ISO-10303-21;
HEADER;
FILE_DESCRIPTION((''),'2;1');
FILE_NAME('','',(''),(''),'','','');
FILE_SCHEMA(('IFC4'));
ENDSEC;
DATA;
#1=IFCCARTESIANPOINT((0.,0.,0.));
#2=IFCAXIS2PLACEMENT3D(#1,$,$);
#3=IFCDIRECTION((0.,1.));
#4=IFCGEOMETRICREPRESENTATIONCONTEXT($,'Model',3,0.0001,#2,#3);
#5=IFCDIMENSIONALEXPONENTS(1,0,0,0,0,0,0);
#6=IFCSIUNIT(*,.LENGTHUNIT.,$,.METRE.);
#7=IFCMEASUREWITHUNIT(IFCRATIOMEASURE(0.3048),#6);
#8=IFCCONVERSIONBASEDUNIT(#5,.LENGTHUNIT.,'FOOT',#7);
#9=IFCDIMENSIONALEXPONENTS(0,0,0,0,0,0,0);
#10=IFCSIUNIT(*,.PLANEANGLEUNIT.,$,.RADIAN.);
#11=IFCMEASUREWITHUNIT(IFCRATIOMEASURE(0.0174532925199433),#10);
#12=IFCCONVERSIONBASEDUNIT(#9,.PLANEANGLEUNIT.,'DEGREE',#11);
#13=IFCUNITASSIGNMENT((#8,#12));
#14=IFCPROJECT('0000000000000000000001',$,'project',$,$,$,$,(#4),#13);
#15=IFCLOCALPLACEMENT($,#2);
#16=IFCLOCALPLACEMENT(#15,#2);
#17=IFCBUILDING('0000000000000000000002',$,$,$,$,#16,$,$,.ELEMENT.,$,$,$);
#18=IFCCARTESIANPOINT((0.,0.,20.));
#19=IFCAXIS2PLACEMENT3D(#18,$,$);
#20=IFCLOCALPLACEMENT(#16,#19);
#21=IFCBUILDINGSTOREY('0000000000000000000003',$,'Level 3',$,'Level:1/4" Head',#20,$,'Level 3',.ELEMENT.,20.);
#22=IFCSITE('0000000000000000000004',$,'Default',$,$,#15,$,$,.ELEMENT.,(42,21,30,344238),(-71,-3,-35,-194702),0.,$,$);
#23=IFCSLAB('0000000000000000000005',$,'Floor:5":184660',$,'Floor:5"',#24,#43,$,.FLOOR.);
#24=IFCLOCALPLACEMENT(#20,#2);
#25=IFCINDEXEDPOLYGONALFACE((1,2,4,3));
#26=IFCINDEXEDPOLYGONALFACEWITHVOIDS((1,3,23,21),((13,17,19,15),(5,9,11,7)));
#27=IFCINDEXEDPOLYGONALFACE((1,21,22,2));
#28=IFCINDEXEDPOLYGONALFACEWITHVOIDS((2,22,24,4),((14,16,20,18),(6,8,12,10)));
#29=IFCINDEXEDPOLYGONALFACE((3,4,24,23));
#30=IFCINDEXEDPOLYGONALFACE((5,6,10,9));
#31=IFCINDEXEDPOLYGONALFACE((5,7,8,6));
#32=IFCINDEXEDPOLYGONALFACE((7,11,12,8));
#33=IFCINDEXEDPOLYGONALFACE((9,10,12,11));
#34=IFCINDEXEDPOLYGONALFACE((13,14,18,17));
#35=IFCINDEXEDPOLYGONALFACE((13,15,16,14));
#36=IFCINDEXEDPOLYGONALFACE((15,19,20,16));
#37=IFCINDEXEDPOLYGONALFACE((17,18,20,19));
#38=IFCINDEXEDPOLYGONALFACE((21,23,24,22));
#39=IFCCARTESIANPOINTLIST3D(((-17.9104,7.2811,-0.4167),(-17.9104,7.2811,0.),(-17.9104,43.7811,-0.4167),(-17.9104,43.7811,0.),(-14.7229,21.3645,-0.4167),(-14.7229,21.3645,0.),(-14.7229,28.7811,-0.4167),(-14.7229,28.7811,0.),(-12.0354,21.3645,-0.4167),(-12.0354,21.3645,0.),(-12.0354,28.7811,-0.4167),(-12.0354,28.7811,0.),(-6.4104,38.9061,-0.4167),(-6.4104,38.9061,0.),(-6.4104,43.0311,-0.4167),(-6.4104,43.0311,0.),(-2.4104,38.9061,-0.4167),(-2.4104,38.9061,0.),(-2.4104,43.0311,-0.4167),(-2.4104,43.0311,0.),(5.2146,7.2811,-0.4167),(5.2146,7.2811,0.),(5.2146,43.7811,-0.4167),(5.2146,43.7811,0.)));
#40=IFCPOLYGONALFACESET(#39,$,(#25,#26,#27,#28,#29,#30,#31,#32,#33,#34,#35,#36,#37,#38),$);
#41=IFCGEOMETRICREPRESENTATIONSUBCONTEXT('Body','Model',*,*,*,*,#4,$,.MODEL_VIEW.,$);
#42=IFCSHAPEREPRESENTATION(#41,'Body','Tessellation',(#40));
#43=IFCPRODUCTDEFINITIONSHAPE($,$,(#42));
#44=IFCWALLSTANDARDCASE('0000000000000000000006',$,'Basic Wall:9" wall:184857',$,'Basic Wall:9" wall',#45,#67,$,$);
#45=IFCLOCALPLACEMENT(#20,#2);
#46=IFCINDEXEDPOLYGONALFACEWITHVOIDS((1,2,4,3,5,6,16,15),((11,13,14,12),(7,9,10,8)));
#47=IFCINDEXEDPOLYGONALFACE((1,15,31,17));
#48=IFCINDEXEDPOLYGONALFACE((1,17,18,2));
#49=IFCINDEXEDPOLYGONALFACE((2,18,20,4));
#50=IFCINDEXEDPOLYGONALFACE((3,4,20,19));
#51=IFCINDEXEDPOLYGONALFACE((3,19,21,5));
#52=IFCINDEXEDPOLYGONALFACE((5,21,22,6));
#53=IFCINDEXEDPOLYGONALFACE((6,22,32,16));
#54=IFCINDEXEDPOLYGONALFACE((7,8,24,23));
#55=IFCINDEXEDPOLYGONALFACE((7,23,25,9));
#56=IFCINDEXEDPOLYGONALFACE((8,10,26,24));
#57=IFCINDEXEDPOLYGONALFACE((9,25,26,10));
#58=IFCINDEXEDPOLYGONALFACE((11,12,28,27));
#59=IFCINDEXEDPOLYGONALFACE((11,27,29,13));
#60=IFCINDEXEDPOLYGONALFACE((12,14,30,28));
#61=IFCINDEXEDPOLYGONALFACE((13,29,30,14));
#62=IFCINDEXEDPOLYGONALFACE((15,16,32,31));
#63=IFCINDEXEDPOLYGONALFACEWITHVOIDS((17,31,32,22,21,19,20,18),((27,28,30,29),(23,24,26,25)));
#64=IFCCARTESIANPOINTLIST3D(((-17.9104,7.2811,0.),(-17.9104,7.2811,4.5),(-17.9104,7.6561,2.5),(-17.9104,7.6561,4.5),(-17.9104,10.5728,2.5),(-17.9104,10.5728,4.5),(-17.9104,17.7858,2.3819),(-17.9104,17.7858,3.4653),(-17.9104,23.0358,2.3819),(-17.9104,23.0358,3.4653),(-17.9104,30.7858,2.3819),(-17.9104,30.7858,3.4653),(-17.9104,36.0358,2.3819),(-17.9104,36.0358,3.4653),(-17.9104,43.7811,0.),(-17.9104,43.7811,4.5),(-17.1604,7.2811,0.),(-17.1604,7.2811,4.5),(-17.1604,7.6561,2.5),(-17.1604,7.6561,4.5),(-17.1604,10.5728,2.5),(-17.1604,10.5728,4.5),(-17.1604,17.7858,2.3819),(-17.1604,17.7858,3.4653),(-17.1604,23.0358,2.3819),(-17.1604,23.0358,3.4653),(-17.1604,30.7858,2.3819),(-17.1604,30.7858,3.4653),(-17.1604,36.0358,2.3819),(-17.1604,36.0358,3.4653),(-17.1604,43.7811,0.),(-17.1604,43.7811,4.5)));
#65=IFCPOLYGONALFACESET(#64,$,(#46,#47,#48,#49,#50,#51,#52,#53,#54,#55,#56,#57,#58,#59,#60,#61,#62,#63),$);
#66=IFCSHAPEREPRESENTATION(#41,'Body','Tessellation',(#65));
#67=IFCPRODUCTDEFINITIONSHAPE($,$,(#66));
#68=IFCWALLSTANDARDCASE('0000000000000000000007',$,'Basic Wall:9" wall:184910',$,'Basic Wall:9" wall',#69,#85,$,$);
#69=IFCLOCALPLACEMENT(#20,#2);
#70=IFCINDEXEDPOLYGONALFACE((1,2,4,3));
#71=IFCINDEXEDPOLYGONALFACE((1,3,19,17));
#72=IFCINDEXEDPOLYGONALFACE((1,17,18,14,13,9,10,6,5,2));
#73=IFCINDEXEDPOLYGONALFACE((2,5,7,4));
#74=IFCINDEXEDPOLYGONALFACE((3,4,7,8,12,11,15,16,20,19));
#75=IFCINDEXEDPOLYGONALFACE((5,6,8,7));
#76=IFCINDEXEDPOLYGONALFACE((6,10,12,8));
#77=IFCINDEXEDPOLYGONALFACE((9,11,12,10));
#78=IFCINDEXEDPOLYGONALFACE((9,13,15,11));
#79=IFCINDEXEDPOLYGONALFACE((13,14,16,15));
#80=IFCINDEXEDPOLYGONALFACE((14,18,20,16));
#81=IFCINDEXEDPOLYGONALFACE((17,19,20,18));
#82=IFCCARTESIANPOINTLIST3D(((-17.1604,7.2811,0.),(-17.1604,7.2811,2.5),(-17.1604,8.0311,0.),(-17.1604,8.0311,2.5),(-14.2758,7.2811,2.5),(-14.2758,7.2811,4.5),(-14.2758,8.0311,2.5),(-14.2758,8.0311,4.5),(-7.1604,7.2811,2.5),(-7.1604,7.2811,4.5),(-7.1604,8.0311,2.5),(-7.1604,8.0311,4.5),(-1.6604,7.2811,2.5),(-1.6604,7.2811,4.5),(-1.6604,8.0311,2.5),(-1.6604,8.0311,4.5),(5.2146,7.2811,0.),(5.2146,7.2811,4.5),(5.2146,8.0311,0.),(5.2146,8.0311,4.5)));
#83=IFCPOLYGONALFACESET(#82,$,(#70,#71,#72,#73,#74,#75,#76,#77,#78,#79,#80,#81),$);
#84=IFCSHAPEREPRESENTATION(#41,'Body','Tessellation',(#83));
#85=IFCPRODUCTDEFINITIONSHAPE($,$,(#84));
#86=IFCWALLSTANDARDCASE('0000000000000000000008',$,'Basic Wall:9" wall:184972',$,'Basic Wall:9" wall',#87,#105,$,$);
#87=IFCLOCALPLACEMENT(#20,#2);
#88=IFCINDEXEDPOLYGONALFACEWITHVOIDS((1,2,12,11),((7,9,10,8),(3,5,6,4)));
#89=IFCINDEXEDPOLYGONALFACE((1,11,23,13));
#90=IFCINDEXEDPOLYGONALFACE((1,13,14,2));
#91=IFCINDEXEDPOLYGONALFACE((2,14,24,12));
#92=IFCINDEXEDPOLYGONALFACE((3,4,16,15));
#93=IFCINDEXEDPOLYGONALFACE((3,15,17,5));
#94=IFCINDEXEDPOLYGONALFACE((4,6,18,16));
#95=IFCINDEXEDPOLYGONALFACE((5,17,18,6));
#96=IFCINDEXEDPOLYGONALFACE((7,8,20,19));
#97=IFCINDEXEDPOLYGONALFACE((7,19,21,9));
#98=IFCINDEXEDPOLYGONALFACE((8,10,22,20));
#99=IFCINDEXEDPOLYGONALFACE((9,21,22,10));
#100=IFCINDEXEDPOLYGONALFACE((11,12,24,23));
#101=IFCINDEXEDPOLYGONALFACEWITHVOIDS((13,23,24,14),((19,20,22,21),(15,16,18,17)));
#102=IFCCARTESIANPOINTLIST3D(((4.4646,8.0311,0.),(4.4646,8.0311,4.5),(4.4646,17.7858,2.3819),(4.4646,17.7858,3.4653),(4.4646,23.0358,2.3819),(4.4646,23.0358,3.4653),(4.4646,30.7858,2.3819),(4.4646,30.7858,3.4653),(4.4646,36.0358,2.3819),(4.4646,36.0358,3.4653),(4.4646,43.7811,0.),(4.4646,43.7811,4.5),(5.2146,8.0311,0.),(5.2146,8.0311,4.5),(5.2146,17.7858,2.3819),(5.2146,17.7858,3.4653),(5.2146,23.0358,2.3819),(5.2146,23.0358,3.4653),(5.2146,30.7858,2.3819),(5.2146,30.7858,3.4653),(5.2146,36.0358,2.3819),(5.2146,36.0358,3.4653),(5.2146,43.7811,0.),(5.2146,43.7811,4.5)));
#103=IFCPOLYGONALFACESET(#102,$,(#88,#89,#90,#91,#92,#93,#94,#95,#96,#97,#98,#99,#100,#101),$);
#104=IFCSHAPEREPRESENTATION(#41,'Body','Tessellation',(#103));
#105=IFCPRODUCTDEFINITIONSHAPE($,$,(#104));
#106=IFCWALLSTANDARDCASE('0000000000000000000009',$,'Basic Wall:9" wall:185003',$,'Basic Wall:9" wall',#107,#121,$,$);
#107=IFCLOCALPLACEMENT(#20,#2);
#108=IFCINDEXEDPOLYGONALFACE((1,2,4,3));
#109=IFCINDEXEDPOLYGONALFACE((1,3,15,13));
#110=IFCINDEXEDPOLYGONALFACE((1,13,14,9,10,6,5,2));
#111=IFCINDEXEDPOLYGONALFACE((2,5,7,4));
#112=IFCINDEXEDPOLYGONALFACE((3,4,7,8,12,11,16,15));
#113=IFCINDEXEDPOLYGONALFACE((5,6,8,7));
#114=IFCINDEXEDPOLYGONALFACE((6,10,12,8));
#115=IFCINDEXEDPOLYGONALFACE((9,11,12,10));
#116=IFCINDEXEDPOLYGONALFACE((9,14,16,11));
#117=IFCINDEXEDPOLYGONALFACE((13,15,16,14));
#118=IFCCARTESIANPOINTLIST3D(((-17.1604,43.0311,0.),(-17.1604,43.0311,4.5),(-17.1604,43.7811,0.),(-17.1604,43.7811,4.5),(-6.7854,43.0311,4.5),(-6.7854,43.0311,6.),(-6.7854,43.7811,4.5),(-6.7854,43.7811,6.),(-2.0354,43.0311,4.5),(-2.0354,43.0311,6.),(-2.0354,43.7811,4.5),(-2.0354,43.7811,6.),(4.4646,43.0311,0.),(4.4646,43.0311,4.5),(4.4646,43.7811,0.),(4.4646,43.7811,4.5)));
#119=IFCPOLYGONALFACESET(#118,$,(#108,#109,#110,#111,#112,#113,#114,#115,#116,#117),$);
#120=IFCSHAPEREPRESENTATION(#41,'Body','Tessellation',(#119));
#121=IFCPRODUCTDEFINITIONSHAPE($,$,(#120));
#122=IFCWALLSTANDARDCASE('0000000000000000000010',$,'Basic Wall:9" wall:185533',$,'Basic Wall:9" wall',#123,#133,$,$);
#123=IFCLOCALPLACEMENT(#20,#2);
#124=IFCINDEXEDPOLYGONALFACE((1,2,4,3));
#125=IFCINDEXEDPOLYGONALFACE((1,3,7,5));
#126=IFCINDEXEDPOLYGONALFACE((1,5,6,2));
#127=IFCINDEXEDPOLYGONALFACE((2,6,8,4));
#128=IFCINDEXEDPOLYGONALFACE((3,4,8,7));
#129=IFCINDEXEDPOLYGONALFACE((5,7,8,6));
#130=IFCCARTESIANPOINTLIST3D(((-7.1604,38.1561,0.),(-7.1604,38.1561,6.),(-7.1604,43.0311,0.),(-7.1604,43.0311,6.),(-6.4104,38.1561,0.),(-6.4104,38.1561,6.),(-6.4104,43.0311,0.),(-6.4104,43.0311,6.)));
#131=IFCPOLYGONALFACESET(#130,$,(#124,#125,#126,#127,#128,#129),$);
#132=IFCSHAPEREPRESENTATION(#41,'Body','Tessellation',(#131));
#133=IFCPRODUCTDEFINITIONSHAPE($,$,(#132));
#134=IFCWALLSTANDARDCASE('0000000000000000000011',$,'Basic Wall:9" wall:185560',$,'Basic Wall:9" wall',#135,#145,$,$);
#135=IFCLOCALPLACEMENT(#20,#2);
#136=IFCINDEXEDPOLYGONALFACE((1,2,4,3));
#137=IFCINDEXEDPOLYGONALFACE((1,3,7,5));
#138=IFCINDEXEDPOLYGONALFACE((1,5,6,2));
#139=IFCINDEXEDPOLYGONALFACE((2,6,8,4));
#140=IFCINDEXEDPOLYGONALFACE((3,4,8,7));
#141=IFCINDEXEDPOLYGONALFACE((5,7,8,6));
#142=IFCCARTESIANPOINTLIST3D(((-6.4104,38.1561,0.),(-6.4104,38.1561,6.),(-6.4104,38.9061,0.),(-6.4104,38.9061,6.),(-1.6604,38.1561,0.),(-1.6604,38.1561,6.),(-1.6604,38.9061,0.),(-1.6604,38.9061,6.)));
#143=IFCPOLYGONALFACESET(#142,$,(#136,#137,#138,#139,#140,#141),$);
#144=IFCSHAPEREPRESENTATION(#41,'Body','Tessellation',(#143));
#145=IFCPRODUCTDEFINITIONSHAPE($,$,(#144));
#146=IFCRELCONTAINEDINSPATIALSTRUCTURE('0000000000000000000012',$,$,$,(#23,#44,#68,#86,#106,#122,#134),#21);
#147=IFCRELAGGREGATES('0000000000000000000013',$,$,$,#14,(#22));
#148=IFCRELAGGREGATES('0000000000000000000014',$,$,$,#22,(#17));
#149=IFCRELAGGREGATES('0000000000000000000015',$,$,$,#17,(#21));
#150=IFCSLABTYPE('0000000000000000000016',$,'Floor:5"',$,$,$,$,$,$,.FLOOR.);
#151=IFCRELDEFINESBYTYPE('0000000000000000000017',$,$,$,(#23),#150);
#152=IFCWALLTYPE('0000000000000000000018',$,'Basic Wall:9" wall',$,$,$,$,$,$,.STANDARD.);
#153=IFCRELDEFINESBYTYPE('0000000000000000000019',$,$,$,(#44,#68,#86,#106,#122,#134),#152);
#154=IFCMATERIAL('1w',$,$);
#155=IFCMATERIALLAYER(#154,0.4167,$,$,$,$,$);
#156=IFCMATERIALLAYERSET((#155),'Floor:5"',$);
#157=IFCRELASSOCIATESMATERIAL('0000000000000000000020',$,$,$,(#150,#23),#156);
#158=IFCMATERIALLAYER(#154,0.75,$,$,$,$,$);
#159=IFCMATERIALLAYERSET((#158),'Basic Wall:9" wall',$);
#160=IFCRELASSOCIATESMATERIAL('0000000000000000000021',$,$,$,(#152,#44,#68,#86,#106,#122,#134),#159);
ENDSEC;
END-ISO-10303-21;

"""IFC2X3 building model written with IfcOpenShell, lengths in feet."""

from ifc_helpers import new_model, entity, si_unit, converted_unit, direction, frame, frame_2d, origin, origin_2d_with_axis, place, context, subcontext, project, spatial, rectangle, extrude, material, layer, layer_set, layer_usage, type_object, element, save


model = new_model("IFC2X3")

# Units and contexts
model_context = context("Model", 3, precision=0.0001, world=origin(), true_north=direction((0.0, 1.0)))
body_context = subcontext(model_context, "Body", "Model", "MODEL_VIEW")
ifc_project = project(units=[converted_unit("LENGTHUNIT", "FOOT", entity("IfcRatioMeasure", 0.3048), si_unit("LENGTHUNIT", "METRE"), dimensions=[1, 0, 0, 0, 0, 0, 0]), converted_unit("PLANEANGLEUNIT", "DEGREE", entity("IfcRatioMeasure", 0.0174532925199433), si_unit("PLANEANGLEUNIT", "RADIAN"), dimensions=[0, 0, 0, 0, 0, 0, 0])], contexts=[model_context])

# Site, building, storey
site_placement = place(None, origin())
site = spatial("IfcSite", under=ifc_project, at=site_placement, Name="Default", CompositionType="ELEMENT", RefLatitude=(42, 21, 30, 344238), RefLongitude=(-71, -3, -35, -194702), RefElevation=0.0)
building_placement = place(site_placement, origin())
building = spatial("IfcBuilding", under=site, at=building_placement, CompositionType="ELEMENT")
storey_placement = place(building_placement, frame((0.0, 0.0, 20.0)))
storey = spatial("IfcBuildingStorey", under=building, at=storey_placement, Name="Level 3", ObjectType="Level:1/4\" Head", LongName="Level 3", CompositionType="ELEMENT", Elevation=20.0)

# Slab, openings
ifc_material = material(Name="1w")
ifc_layer_1 = layer(ifc_material, 0.4167)
ifc_layer_set_1 = layer_set([ifc_layer_1], Name="Floor:5\"")
ifc_layer_usage_1 = layer_usage(ifc_layer_set_1, "AXIS3", "POSITIVE", 0.0)
slab_type = type_object("IfcSlabType", Name="Floor:5\"", PredefinedType="FLOOR", material=ifc_layer_set_1)
slab_placement = place(storey_placement, frame((-17.9104, 7.2811, -0.4167)))
slab = element("IfcSlab", 1, at=slab_placement, inside=storey, type_object=slab_type, material=ifc_layer_usage_1, Name="Floor:5\":184660", ObjectType="Floor:5\"", PredefinedType="FLOOR", context=body_context, shape_type="SweptSolid", body=[
    extrude(rectangle(XDim=36.5, YDim=23.125, at=frame_2d((0.0, 0.0), x_axis=(0.0, -1.0))), frame((11.5625, 18.25, 0.4167), z_axis=(0.0, 0.0, -1.0), x_axis=(-1.0, 0.0, 0.0)), (0.0, 0.0, 1.0), 0.4167),
])
opening_1_placement = place(slab_placement, frame((4.5312, 17.7917, 0.4167)))
element("IfcOpeningElement", 2, at=opening_1_placement, cuts=slab, ObjectType="Opening", context=body_context, shape_type="SweptSolid", body=[
    extrude(rectangle(XDim=7.4167, YDim=2.6875, at=origin_2d_with_axis()), frame((0.0, 0.0, 0.0), z_axis=(0.0, 0.0, -1.0), x_axis=(0.0, 1.0, 0.0)), (0.0, 0.0, 1.0), 0.4167),
])
opening_2_placement = place(slab_placement, frame((13.5, 33.6875, 0.4167)))
element("IfcOpeningElement", 3, at=opening_2_placement, cuts=slab, ObjectType="Opening", context=body_context, shape_type="SweptSolid", body=[
    extrude(rectangle(XDim=4.0, YDim=4.125, at=origin_2d_with_axis()), frame((0.0, 0.0, 0.0), z_axis=(0.0, 0.0, -1.0), x_axis=(1.0, 0.0, 0.0)), (0.0, 0.0, 1.0), 0.4167),
])

# Walls, openings
ifc_layer_2 = layer(ifc_material, 0.75)
ifc_layer_set_2 = layer_set([ifc_layer_2], Name="Basic Wall:9\" wall")
ifc_layer_usage_2 = layer_usage(ifc_layer_set_2, "AXIS2", "POSITIVE", -0.375)
wall_type = type_object("IfcWallType", Name="Basic Wall:9\" wall", PredefinedType="STANDARD", material=ifc_layer_set_2)
wall_1_placement = place(storey_placement, frame((-17.5354, 43.7811, 0.0), z_axis=(0.0, 0.0, 1.0), x_axis=(0.0, -1.0, 0.0)))
wall_1 = element("IfcWallStandardCase", 4, at=wall_1_placement, inside=storey, type_object=wall_type, material=ifc_layer_usage_2, Name="Basic Wall:9\" wall:184857", ObjectType="Basic Wall:9\" wall", context=body_context, shape_type="SweptSolid", body=[
    extrude(rectangle(XDim=36.5, YDim=0.75, at=frame_2d((18.25, 0.0), x_axis=(-1.0, 0.0))), origin(), (0.0, 0.0, 1.0), 4.5),
])
opening_3_placement = place(wall_1_placement, origin())
element("IfcOpeningElement", 5, at=opening_3_placement, cuts=wall_1, ObjectType="Opening", context=body_context, shape_type="SweptSolid", body=[
    extrude(rectangle(XDim=1.0833, YDim=5.25, at=frame_2d((0.0, 0.0), x_axis=(0.0, 1.0))), frame((10.3703, 0.375, 2.9236), z_axis=(0.0, -1.0, 0.0), x_axis=(-1.0, 0.0, 0.0)), (0.0, 0.0, 1.0), 0.75),
])
opening_4_placement = place(wall_1_placement, origin())
element("IfcOpeningElement", 6, at=opening_4_placement, cuts=wall_1, ObjectType="Opening", context=body_context, shape_type="SweptSolid", body=[
    extrude(rectangle(XDim=1.0833, YDim=5.25, at=frame_2d((0.0, 0.0), x_axis=(0.0, 1.0))), frame((23.3703, 0.375, 2.9236), z_axis=(0.0, -1.0, 0.0), x_axis=(-1.0, 0.0, 0.0)), (0.0, 0.0, 1.0), 0.75),
])
opening_5_placement = place(wall_1_placement, origin())
element("IfcOpeningElement", 7, at=opening_5_placement, cuts=wall_1, ObjectType="Opening", context=body_context, shape_type="SweptSolid", body=[
    extrude(rectangle(XDim=2.0, YDim=2.9167, at=frame_2d((0.0, 0.0), x_axis=(1.0, 0.0))), frame((34.6667, 0.375, 3.5), z_axis=(0.0, -1.0, 0.0), x_axis=(0.0, 0.0, 1.0)), (0.0, 0.0, 1.0), 0.75),
])
ifc_layer_usage_3 = layer_usage(ifc_layer_set_2, "AXIS2", "POSITIVE", -0.375)
wall_2_placement = place(storey_placement, frame((-17.1604, 7.6561, 0.0)))
wall_2 = element("IfcWallStandardCase", 8, at=wall_2_placement, inside=storey, type_object=wall_type, material=ifc_layer_usage_3, Name="Basic Wall:9\" wall:184910", ObjectType="Basic Wall:9\" wall", context=body_context, shape_type="SweptSolid", body=[
    extrude(rectangle(XDim=22.375, YDim=0.75, at=frame_2d((11.1875, 0.0), x_axis=(-1.0, 0.0))), origin(), (0.0, 0.0, 1.0), 4.5),
])
opening_6_placement = place(wall_2_placement, origin())
element("IfcOpeningElement", 9, at=opening_6_placement, cuts=wall_2, ObjectType="Opening", context=body_context, shape_type="SweptSolid", body=[
    extrude(rectangle(XDim=2.0, YDim=5.5, at=frame_2d((0.0, 0.0), x_axis=(0.0, 1.0))), frame((12.75, 0.375, 3.5), z_axis=(0.0, -1.0, 0.0), x_axis=(-1.0, 0.0, 0.0)), (0.0, 0.0, 1.0), 0.75),
])
opening_7_placement = place(wall_2_placement, origin())
element("IfcOpeningElement", 10, at=opening_7_placement, cuts=wall_2, ObjectType="Opening", context=body_context, shape_type="SweptSolid", body=[
    extrude(rectangle(XDim=2.0, YDim=3.2597, at=frame_2d((0.0, 0.0), x_axis=(0.0, 1.0))), frame((1.2548, 0.375, 3.5), z_axis=(0.0, -1.0, 0.0), x_axis=(-1.0, 0.0, 0.0)), (0.0, 0.0, 1.0), 0.75),
])
ifc_layer_usage_4 = layer_usage(ifc_layer_set_2, "AXIS2", "POSITIVE", -0.375)
wall_3_placement = place(storey_placement, frame((4.8396, 8.0311, 0.0), z_axis=(0.0, 0.0, 1.0), x_axis=(0.0, 1.0, 0.0)))
wall_3 = element("IfcWallStandardCase", 11, at=wall_3_placement, inside=storey, type_object=wall_type, material=ifc_layer_usage_4, Name="Basic Wall:9\" wall:184972", ObjectType="Basic Wall:9\" wall", context=body_context, shape_type="SweptSolid", body=[
    extrude(rectangle(XDim=35.75, YDim=0.75, at=frame_2d((17.875, 0.0), x_axis=(-1.0, 0.0))), origin(), (0.0, 0.0, 1.0), 4.5),
])
opening_8_placement = place(wall_3_placement, origin())
element("IfcOpeningElement", 12, at=opening_8_placement, cuts=wall_3, ObjectType="Opening", context=body_context, shape_type="SweptSolid", body=[
    extrude(rectangle(XDim=1.0833, YDim=5.25, at=frame_2d((0.0, 0.0), x_axis=(0.0, 1.0))), frame((12.3797, 0.375, 2.9236), z_axis=(0.0, -1.0, 0.0), x_axis=(-1.0, 0.0, 0.0)), (0.0, 0.0, 1.0), 0.75),
])
opening_9_placement = place(wall_3_placement, origin())
element("IfcOpeningElement", 13, at=opening_9_placement, cuts=wall_3, ObjectType="Opening", context=body_context, shape_type="SweptSolid", body=[
    extrude(rectangle(XDim=1.0833, YDim=5.25, at=frame_2d((0.0, 0.0), x_axis=(0.0, 1.0))), frame((25.3797, 0.375, 2.9236), z_axis=(0.0, -1.0, 0.0), x_axis=(-1.0, 0.0, 0.0)), (0.0, 0.0, 1.0), 0.75),
])
ifc_layer_usage_5 = layer_usage(ifc_layer_set_2, "AXIS2", "POSITIVE", -0.375)
wall_4_placement = place(storey_placement, frame((4.4646, 43.4061, 0.0), z_axis=(0.0, 0.0, 1.0), x_axis=(-1.0, 0.0, 0.0)))
wall_4 = element("IfcWallStandardCase", 14, at=wall_4_placement, inside=storey, type_object=wall_type, material=ifc_layer_usage_5, Name="Basic Wall:9\" wall:185003", ObjectType="Basic Wall:9\" wall", context=body_context, shape_type="SweptSolid", body=[
    extrude(rectangle(XDim=21.625, YDim=0.75, at=frame_2d((10.8125, 0.0), x_axis=(-1.0, 0.0))), origin(), (0.0, 0.0, 1.0), 6.0),
])
opening_10_placement = place(wall_4_placement, origin())
element("IfcOpeningElement", 15, at=opening_10_placement, cuts=wall_4, ObjectType="Opening", context=body_context, shape_type="SweptSolid", body=[
    extrude(rectangle(XDim=1.5, YDim=10.75, at=frame_2d((0.0, 0.0), x_axis=(1.0, 0.0))), frame((16.625, 0.375, 5.25), z_axis=(0.0, -1.0, 0.0), x_axis=(0.0, 0.0, 1.0)), (0.0, 0.0, 1.0), 0.75),
])
opening_11_placement = place(wall_4_placement, origin())
element("IfcOpeningElement", 16, at=opening_11_placement, cuts=wall_4, ObjectType="Opening", context=body_context, shape_type="SweptSolid", body=[
    extrude(rectangle(XDim=1.5, YDim=6.875, at=frame_2d((0.0, 0.0), x_axis=(0.0, 1.0))), frame((3.0625, 0.375, 5.25), z_axis=(0.0, -1.0, 0.0), x_axis=(-1.0, 0.0, 0.0)), (0.0, 0.0, 1.0), 0.75),
])

# Walls
ifc_layer_usage_6 = layer_usage(ifc_layer_set_2, "AXIS2", "NEGATIVE", 0.375)
wall_5_placement = place(storey_placement, frame((-6.7854, 43.0311, 0.0), z_axis=(0.0, 0.0, 1.0), x_axis=(0.0, -1.0, 0.0)))
element("IfcWallStandardCase", 17, at=wall_5_placement, inside=storey, type_object=wall_type, material=ifc_layer_usage_6, Name="Basic Wall:9\" wall:185533", ObjectType="Basic Wall:9\" wall", context=body_context, shape_type="SweptSolid", body=[
    extrude(rectangle(XDim=4.875, YDim=0.75, at=frame_2d((2.4375, 0.0), x_axis=(-1.0, 0.0))), origin(), (0.0, 0.0, 1.0), 6.0),
])
ifc_layer_usage_7 = layer_usage(ifc_layer_set_2, "AXIS2", "NEGATIVE", 0.375)
wall_6_placement = place(storey_placement, frame((-6.4104, 38.5311, 0.0)))
element("IfcWallStandardCase", 18, at=wall_6_placement, inside=storey, type_object=wall_type, material=ifc_layer_usage_7, Name="Basic Wall:9\" wall:185560", ObjectType="Basic Wall:9\" wall", context=body_context, shape_type="SweptSolid", body=[
    extrude(rectangle(XDim=4.75, YDim=0.75, at=frame_2d((2.375, 0.0), x_axis=(-1.0, 0.0))), origin(), (0.0, 0.0, 1.0), 6.0),
])

save(model, "model.ifc")
